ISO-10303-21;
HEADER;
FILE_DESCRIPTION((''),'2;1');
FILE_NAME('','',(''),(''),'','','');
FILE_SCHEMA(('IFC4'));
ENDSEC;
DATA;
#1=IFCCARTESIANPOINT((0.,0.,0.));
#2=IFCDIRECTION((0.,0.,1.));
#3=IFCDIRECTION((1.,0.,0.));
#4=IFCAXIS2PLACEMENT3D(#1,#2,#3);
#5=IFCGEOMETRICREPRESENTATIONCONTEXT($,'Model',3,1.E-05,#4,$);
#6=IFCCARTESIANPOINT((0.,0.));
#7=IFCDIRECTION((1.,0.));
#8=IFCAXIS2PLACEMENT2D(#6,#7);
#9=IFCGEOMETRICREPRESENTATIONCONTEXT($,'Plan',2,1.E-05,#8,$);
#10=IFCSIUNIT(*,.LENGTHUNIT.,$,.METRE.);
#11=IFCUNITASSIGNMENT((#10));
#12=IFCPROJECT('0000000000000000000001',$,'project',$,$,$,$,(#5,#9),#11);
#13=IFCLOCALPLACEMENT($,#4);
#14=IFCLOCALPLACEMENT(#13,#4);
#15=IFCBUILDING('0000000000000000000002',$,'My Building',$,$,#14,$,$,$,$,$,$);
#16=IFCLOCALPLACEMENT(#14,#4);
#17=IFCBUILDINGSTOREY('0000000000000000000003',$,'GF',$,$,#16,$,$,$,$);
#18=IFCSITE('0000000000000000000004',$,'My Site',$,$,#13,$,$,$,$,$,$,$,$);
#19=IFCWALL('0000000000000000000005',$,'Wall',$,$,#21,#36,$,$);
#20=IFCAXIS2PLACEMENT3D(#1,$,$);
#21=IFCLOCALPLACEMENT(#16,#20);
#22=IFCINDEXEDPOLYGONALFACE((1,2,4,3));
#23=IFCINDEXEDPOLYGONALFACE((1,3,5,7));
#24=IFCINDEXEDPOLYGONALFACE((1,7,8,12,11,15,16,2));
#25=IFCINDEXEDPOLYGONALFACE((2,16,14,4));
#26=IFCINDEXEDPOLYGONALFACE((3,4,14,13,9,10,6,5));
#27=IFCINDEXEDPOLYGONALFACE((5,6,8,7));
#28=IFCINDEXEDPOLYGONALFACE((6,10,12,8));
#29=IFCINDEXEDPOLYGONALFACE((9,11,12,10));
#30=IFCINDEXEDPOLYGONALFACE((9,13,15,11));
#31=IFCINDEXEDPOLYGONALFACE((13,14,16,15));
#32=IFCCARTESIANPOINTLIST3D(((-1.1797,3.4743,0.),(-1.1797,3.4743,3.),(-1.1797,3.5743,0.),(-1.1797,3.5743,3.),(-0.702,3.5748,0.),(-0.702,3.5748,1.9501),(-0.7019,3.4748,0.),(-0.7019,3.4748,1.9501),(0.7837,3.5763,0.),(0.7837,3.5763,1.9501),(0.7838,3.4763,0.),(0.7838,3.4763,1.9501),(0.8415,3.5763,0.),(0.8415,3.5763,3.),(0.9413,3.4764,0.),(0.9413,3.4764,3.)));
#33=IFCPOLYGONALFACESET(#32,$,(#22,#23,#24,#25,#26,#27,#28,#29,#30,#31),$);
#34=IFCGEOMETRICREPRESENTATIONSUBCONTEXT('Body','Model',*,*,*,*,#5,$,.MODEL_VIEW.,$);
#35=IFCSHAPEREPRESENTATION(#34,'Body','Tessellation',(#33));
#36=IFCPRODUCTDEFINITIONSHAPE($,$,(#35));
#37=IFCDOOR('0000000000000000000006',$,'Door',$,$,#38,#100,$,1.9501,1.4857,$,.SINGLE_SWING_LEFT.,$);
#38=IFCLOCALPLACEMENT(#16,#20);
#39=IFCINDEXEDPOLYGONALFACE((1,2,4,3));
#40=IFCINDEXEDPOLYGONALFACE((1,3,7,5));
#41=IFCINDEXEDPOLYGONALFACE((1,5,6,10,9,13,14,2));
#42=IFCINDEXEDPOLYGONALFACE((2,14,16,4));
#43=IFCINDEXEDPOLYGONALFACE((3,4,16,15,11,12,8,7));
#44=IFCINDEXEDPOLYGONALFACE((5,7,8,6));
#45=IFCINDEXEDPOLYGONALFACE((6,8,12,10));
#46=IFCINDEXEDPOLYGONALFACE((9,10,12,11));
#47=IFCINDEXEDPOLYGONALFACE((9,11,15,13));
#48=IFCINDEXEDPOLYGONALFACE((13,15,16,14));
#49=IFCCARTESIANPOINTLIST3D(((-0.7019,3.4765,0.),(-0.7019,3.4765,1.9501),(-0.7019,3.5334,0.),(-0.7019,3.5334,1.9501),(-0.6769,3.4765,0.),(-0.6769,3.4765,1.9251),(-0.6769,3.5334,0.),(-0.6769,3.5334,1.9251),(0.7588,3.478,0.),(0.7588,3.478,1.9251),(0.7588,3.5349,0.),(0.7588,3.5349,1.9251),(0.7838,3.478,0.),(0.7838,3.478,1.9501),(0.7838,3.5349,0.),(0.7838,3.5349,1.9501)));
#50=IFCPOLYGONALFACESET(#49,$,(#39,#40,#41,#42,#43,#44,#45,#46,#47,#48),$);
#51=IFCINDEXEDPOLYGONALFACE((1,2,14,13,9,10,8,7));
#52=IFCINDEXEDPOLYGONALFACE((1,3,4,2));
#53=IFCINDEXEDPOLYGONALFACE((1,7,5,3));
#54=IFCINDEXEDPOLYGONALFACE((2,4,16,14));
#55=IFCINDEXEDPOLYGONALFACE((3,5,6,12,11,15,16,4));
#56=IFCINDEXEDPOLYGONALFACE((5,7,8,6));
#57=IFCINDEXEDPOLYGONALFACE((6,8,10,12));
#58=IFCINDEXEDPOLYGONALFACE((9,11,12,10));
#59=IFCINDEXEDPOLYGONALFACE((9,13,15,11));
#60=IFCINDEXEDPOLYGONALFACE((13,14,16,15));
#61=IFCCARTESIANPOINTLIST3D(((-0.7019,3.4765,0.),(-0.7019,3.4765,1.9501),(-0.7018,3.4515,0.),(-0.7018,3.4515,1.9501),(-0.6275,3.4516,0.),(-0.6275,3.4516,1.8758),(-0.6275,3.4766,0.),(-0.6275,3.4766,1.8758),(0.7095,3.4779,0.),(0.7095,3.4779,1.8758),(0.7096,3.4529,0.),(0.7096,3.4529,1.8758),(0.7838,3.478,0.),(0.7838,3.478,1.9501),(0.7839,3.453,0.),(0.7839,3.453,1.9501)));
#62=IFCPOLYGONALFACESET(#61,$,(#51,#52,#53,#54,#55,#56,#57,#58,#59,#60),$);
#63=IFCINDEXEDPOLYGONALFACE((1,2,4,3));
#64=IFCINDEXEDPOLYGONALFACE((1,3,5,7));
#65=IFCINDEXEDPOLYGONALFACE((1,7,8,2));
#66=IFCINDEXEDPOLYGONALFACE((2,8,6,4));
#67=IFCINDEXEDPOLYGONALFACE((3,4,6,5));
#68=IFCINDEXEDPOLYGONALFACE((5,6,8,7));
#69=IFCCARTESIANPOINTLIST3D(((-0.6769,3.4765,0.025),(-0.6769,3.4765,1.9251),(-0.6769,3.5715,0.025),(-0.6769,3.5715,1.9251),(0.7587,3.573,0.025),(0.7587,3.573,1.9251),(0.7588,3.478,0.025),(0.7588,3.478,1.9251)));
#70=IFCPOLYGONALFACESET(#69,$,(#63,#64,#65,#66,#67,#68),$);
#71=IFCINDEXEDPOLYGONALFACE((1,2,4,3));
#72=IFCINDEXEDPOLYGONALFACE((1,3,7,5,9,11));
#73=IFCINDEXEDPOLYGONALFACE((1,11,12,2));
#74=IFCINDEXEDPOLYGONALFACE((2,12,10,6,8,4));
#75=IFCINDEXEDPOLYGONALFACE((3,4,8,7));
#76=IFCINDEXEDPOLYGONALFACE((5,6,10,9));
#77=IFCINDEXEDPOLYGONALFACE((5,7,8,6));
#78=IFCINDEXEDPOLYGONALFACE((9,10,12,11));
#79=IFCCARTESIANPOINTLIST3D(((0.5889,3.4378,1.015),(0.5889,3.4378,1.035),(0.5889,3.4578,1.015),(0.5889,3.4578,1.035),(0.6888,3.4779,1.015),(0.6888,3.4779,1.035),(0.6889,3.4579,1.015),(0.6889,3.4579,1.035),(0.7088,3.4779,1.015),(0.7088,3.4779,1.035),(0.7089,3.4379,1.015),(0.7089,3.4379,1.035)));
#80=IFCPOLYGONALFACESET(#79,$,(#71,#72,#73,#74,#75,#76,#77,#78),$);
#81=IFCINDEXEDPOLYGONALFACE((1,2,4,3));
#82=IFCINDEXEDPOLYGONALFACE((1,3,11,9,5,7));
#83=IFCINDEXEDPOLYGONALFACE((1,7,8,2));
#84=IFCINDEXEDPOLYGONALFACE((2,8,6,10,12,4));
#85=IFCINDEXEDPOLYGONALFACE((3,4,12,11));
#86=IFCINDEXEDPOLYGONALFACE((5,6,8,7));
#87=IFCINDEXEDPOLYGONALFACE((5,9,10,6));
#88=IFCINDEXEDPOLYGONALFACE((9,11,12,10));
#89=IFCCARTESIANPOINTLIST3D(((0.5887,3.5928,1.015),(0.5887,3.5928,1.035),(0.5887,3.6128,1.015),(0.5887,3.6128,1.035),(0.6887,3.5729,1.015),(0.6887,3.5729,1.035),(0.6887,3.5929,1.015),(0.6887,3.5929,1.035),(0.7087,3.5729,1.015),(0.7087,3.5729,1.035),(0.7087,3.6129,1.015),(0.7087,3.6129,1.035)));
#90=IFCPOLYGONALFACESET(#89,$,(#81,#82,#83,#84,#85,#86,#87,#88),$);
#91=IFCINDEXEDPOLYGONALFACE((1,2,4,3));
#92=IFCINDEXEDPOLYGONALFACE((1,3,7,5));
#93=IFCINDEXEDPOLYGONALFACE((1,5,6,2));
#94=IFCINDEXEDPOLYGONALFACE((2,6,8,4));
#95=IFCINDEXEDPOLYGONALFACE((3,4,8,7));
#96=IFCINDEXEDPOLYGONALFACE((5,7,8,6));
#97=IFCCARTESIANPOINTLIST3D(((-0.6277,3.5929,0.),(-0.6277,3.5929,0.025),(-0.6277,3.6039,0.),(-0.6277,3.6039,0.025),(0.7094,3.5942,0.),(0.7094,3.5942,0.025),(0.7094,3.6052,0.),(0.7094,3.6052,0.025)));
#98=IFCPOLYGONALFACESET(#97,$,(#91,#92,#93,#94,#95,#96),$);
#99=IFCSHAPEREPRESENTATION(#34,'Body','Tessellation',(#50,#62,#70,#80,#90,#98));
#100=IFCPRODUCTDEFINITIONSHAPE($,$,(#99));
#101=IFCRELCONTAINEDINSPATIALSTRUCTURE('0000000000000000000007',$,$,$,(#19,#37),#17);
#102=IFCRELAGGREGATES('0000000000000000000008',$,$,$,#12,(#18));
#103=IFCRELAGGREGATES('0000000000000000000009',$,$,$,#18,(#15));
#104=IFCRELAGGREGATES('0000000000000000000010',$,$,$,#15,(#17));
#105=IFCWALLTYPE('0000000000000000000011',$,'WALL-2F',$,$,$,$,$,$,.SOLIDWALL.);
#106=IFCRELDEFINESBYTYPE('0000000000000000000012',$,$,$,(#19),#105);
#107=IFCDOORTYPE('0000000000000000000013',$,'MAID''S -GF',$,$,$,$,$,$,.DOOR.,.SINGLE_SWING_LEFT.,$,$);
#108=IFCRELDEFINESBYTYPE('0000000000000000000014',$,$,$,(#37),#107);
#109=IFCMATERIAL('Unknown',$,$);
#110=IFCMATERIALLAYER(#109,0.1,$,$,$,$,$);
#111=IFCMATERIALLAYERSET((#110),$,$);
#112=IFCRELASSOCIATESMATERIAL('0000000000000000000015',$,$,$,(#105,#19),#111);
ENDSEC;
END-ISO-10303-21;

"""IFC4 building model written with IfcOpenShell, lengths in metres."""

from ifc_helpers import new_model, entity, si_unit, frame, origin_with_axes, origin_2d_with_axis, place, context, subcontext, project, spatial, line, indexed_curve, outline, extrude, shape, source, transform, mapped, material, layer, layer_set, layer_usage, type_object, type_shapes, element, fill, save


model = new_model("IFC4")

# Units and contexts
model_context = context("Model", 3, precision=1e-05, world=origin_with_axes())
plan_context = context("Plan", 2, precision=1e-05, world=origin_2d_with_axis())
body_context_1 = subcontext(model_context, "Body", "Model", "MODEL_VIEW")
body_context_2 = subcontext(plan_context, "Body", "Plan", "PLAN_VIEW")
ifc_project = project(units=[si_unit("LENGTHUNIT", "METRE")], contexts=[model_context, plan_context])

# Site, building, storey
site_placement = place(None, origin_with_axes())
site = spatial("IfcSite", under=ifc_project, at=site_placement, Name="My Site")
building_placement = place(site_placement, origin_with_axes())
building = spatial("IfcBuilding", under=site, at=building_placement, Name="My Building")
storey_placement = place(building_placement, origin_with_axes())
storey = spatial("IfcBuildingStorey", under=building, at=storey_placement, Name="GF")

# Shared definitions
ifc_material_1 = material(Name="Unknown")

# Shared definitions
ifc_layer_1 = layer(ifc_material_1, 0.1)
ifc_layer_set_1 = layer_set([ifc_layer_1])
wall_type_1 = type_object("IfcWallType", Name="WALL-2F", PredefinedType="SOLIDWALL", material=ifc_layer_set_1)

# Wall, opening, door
ifc_layer_usage_1 = layer_usage(ifc_layer_set_1, "AXIS2", "POSITIVE", 0.0)
wall_1_placement = place(storey_placement, frame((0.8415, 3.5763, 0.0), z_axis=(0.0, 0.0, 1.0), x_axis=(-1.0, -0.000997, 0.0)))
wall_1 = element("IfcWall", 1, at=wall_1_placement, inside=storey, type_object=wall_type_1, material=ifc_layer_usage_1, Name="Wall", context=body_context_1, shape_type="SweptSolid", body=[
    extrude(outline(indexed_curve([(0.0, 0.0), (-0.0997, 0.1), (2.0213, 0.1), (2.0212, 0.0)], segments=[line(1, 2, 3, 4, 1)])), origin_with_axes(), (0.0, 0.0, 1.0), 3.0),
])
shared_shape_1 = source(origin_with_axes(), body_context_1, "Body", "SweptSolid", [
    extrude(outline(indexed_curve([(0.0, 0.0), (1.4857, 0.0), (1.4857, 1.9501), (0.0, 1.9501)], segments=[line(1, 2, 3, 4, 1)])), frame((0.0, -0.6, 0.0), z_axis=(0.0, -1.0, 0.0), x_axis=(1.0, 0.0, 0.0)), (0.0, 0.0, -1.0), 1.2),
])
opening_1_placement = place(wall_1_placement, frame((1.5436, 0.19, 0.0), z_axis=(0.0, 0.0, 1.0), x_axis=(-1.0, 0.000001, 0.0)))
opening_1 = element("IfcOpeningElement", 2, at=opening_1_placement, cuts=wall_1, PredefinedType="OPENING", context=body_context_1, shape_type="MappedRepresentation", body=[
    mapped(shared_shape_1, transform((0.0, 0.0, 0.0), x_axis=(1.0, 0.0, 0.0), y_axis=(0.0, 1.0, 0.0), z_axis=(0.0, 0.0, 1.0), scale=1.0)),
])
door_type_1 = type_object("IfcDoorType", Name="MAID'S -GF", OperationType="SINGLE_SWING_LEFT", PredefinedType="DOOR")
shared_shape_2 = source(origin_with_axes(), body_context_1, "Body", "SweptSolid", [
    extrude(outline(indexed_curve([(0.0, 0.0), (0.0, 1.9501), (1.4857, 1.9501), (1.4857, 0.0), (1.4607, 0.0), (1.4607, 1.9251), (0.025, 1.9251), (0.025, 0.0)], segments=[line(1, 2, 3, 4, 5, 6, 7, 8, 1)])), frame((0.0, 0.0093, 0.0), z_axis=(0.0, -1.0, 0.0), x_axis=(1.0, 0.0, 0.0)), (0.0, 0.0, -1.0), 0.0569),
    extrude(outline(indexed_curve([(0.0, 0.0), (0.0, 1.9501), (1.4857, 1.9501), (1.4857, 0.0), (1.4114, 0.0), (1.4114, 1.8758), (0.0743, 1.8758), (0.0743, 0.0)], segments=[line(1, 2, 3, 4, 5, 6, 7, 8, 1)])), frame((0.0, -0.0157, 0.0), z_axis=(0.0, -1.0, 0.0), x_axis=(1.0, 0.0, 0.0)), (0.0, 0.0, -1.0), 0.025),
    extrude(outline(indexed_curve([(0.0, 0.0), (1.4357, 0.0), (1.4357, 0.095), (0.0, 0.095)], segments=[line(1, 2, 3, 4, 1)])), frame((0.025, 0.0093, 0.025), z_axis=(0.0, 0.0, 1.0), x_axis=(1.0, 0.0, 0.0)), (0.0, 0.0, 1.0), 1.9001),
    extrude(outline(indexed_curve([(0.0, 0.0), (0.0, -0.04), (-0.12, -0.04), (-0.12, -0.02), (-0.02, -0.02), (-0.02, 0.0)], segments=[line(1, 2, 3, 4, 5, 6, 1)])), frame((1.4107, 0.0093, 1.015), z_axis=(0.0, 0.0, 1.0), x_axis=(1.0, 0.0, 0.0)), (0.0, 0.0, 1.0), 0.02),
    extrude(outline(indexed_curve([(0.0, 0.0), (0.0, 0.04), (-0.12, 0.04), (-0.12, 0.02), (-0.02, 0.02), (-0.02, 0.0)], segments=[line(1, 2, 3, 4, 5, 6, 1)])), frame((1.4107, 0.1043, 1.015), z_axis=(0.0, 0.0, 1.0), x_axis=(1.0, 0.0, 0.0)), (0.0, 0.0, 1.0), 0.02),
    extrude(outline(indexed_curve([(0.0, 0.0), (1.3371, 0.0), (1.3371, 0.011), (0.0, 0.011)], segments=[line(1, 2, 3, 4, 1)])), frame((0.0743, 0.1256, 0.0), z_axis=(0.0, 0.0, 1.0), x_axis=(1.0, 0.0, 0.0)), (0.0, 0.0, 1.0), 0.025),
])
shared_shape_3 = source(origin_with_axes(), body_context_2, "Body", "Curve2D", [
    entity("IfcIndexedPolyCurve", entity("IfcCartesianPointList2D", [[0.0, -0.0157], [0.0, 0.0662], [0.025, 0.0662], [0.025, 0.0093], [0.0743, 0.0093], [0.0743, -0.0157]]), [entity("IfcLineIndex", [1, 2, 3, 4, 5, 6, 1])]),
    entity("IfcIndexedPolyCurve", entity("IfcCartesianPointList2D", [[1.4857, -0.0157], [1.4857, 0.0662], [1.4607, 0.0662], [1.4607, 0.0093], [1.4114, 0.0093], [1.4114, -0.0157]]), [entity("IfcLineIndex", [1, 2, 3, 4, 5, 6, 1])]),
    entity("IfcTrimmedCurve", entity("IfcEllipse", entity("IfcAxis2Placement2D", entity("IfcCartesianPoint", [0.12, 0.0662]), entity("IfcDirection", [1.0, 0.0])), 1.3407, 1.4357), [entity("IfcCartesianPoint", [1.4607, 0.0662])], [entity("IfcCartesianPoint", [0.12, 1.5019])], True, "CARTESIAN"),
    entity("IfcIndexedPolyCurve", entity("IfcCartesianPointList2D", [[0.025, 0.0662], [0.12, 0.0662], [0.12, 1.5019], [0.025, 1.5019]]), [entity("IfcLineIndex", [1, 2, 3, 4, 1])]),
])
type_shapes(door_type_1, [shared_shape_2, shared_shape_3])
door_1_placement = place(opening_1_placement, frame((0.0001, 0.0824, 0.0), z_axis=(0.0, 0.0, 1.0), x_axis=(1.0, 0.0, 0.0)))
door_1 = element("IfcDoor", 3, at=door_1_placement, inside=storey, type_object=door_type_1, Name="Door", OperationType="SINGLE_SWING_LEFT", OverallHeight=1.9501, OverallWidth=1.4857, shapes=[
    shape(body_context_1, "Body", "MappedRepresentation", [mapped(shared_shape_2, transform((0.0, 0.0, 0.0), x_axis=(1.0, 0.0, 0.0), y_axis=(0.0, 1.0, 0.0), z_axis=(0.0, 0.0, 1.0), scale=1.0))]),
    shape(body_context_2, "Body", "MappedRepresentation", [mapped(shared_shape_3, transform((0.0, 0.0, 0.0), x_axis=(1.0, 0.0, 0.0), y_axis=(0.0, 1.0, 0.0), z_axis=(0.0, 0.0, 1.0), scale=1.0))]),
])
fill(opening_1, door_1)

save(model, "model.ifc")
